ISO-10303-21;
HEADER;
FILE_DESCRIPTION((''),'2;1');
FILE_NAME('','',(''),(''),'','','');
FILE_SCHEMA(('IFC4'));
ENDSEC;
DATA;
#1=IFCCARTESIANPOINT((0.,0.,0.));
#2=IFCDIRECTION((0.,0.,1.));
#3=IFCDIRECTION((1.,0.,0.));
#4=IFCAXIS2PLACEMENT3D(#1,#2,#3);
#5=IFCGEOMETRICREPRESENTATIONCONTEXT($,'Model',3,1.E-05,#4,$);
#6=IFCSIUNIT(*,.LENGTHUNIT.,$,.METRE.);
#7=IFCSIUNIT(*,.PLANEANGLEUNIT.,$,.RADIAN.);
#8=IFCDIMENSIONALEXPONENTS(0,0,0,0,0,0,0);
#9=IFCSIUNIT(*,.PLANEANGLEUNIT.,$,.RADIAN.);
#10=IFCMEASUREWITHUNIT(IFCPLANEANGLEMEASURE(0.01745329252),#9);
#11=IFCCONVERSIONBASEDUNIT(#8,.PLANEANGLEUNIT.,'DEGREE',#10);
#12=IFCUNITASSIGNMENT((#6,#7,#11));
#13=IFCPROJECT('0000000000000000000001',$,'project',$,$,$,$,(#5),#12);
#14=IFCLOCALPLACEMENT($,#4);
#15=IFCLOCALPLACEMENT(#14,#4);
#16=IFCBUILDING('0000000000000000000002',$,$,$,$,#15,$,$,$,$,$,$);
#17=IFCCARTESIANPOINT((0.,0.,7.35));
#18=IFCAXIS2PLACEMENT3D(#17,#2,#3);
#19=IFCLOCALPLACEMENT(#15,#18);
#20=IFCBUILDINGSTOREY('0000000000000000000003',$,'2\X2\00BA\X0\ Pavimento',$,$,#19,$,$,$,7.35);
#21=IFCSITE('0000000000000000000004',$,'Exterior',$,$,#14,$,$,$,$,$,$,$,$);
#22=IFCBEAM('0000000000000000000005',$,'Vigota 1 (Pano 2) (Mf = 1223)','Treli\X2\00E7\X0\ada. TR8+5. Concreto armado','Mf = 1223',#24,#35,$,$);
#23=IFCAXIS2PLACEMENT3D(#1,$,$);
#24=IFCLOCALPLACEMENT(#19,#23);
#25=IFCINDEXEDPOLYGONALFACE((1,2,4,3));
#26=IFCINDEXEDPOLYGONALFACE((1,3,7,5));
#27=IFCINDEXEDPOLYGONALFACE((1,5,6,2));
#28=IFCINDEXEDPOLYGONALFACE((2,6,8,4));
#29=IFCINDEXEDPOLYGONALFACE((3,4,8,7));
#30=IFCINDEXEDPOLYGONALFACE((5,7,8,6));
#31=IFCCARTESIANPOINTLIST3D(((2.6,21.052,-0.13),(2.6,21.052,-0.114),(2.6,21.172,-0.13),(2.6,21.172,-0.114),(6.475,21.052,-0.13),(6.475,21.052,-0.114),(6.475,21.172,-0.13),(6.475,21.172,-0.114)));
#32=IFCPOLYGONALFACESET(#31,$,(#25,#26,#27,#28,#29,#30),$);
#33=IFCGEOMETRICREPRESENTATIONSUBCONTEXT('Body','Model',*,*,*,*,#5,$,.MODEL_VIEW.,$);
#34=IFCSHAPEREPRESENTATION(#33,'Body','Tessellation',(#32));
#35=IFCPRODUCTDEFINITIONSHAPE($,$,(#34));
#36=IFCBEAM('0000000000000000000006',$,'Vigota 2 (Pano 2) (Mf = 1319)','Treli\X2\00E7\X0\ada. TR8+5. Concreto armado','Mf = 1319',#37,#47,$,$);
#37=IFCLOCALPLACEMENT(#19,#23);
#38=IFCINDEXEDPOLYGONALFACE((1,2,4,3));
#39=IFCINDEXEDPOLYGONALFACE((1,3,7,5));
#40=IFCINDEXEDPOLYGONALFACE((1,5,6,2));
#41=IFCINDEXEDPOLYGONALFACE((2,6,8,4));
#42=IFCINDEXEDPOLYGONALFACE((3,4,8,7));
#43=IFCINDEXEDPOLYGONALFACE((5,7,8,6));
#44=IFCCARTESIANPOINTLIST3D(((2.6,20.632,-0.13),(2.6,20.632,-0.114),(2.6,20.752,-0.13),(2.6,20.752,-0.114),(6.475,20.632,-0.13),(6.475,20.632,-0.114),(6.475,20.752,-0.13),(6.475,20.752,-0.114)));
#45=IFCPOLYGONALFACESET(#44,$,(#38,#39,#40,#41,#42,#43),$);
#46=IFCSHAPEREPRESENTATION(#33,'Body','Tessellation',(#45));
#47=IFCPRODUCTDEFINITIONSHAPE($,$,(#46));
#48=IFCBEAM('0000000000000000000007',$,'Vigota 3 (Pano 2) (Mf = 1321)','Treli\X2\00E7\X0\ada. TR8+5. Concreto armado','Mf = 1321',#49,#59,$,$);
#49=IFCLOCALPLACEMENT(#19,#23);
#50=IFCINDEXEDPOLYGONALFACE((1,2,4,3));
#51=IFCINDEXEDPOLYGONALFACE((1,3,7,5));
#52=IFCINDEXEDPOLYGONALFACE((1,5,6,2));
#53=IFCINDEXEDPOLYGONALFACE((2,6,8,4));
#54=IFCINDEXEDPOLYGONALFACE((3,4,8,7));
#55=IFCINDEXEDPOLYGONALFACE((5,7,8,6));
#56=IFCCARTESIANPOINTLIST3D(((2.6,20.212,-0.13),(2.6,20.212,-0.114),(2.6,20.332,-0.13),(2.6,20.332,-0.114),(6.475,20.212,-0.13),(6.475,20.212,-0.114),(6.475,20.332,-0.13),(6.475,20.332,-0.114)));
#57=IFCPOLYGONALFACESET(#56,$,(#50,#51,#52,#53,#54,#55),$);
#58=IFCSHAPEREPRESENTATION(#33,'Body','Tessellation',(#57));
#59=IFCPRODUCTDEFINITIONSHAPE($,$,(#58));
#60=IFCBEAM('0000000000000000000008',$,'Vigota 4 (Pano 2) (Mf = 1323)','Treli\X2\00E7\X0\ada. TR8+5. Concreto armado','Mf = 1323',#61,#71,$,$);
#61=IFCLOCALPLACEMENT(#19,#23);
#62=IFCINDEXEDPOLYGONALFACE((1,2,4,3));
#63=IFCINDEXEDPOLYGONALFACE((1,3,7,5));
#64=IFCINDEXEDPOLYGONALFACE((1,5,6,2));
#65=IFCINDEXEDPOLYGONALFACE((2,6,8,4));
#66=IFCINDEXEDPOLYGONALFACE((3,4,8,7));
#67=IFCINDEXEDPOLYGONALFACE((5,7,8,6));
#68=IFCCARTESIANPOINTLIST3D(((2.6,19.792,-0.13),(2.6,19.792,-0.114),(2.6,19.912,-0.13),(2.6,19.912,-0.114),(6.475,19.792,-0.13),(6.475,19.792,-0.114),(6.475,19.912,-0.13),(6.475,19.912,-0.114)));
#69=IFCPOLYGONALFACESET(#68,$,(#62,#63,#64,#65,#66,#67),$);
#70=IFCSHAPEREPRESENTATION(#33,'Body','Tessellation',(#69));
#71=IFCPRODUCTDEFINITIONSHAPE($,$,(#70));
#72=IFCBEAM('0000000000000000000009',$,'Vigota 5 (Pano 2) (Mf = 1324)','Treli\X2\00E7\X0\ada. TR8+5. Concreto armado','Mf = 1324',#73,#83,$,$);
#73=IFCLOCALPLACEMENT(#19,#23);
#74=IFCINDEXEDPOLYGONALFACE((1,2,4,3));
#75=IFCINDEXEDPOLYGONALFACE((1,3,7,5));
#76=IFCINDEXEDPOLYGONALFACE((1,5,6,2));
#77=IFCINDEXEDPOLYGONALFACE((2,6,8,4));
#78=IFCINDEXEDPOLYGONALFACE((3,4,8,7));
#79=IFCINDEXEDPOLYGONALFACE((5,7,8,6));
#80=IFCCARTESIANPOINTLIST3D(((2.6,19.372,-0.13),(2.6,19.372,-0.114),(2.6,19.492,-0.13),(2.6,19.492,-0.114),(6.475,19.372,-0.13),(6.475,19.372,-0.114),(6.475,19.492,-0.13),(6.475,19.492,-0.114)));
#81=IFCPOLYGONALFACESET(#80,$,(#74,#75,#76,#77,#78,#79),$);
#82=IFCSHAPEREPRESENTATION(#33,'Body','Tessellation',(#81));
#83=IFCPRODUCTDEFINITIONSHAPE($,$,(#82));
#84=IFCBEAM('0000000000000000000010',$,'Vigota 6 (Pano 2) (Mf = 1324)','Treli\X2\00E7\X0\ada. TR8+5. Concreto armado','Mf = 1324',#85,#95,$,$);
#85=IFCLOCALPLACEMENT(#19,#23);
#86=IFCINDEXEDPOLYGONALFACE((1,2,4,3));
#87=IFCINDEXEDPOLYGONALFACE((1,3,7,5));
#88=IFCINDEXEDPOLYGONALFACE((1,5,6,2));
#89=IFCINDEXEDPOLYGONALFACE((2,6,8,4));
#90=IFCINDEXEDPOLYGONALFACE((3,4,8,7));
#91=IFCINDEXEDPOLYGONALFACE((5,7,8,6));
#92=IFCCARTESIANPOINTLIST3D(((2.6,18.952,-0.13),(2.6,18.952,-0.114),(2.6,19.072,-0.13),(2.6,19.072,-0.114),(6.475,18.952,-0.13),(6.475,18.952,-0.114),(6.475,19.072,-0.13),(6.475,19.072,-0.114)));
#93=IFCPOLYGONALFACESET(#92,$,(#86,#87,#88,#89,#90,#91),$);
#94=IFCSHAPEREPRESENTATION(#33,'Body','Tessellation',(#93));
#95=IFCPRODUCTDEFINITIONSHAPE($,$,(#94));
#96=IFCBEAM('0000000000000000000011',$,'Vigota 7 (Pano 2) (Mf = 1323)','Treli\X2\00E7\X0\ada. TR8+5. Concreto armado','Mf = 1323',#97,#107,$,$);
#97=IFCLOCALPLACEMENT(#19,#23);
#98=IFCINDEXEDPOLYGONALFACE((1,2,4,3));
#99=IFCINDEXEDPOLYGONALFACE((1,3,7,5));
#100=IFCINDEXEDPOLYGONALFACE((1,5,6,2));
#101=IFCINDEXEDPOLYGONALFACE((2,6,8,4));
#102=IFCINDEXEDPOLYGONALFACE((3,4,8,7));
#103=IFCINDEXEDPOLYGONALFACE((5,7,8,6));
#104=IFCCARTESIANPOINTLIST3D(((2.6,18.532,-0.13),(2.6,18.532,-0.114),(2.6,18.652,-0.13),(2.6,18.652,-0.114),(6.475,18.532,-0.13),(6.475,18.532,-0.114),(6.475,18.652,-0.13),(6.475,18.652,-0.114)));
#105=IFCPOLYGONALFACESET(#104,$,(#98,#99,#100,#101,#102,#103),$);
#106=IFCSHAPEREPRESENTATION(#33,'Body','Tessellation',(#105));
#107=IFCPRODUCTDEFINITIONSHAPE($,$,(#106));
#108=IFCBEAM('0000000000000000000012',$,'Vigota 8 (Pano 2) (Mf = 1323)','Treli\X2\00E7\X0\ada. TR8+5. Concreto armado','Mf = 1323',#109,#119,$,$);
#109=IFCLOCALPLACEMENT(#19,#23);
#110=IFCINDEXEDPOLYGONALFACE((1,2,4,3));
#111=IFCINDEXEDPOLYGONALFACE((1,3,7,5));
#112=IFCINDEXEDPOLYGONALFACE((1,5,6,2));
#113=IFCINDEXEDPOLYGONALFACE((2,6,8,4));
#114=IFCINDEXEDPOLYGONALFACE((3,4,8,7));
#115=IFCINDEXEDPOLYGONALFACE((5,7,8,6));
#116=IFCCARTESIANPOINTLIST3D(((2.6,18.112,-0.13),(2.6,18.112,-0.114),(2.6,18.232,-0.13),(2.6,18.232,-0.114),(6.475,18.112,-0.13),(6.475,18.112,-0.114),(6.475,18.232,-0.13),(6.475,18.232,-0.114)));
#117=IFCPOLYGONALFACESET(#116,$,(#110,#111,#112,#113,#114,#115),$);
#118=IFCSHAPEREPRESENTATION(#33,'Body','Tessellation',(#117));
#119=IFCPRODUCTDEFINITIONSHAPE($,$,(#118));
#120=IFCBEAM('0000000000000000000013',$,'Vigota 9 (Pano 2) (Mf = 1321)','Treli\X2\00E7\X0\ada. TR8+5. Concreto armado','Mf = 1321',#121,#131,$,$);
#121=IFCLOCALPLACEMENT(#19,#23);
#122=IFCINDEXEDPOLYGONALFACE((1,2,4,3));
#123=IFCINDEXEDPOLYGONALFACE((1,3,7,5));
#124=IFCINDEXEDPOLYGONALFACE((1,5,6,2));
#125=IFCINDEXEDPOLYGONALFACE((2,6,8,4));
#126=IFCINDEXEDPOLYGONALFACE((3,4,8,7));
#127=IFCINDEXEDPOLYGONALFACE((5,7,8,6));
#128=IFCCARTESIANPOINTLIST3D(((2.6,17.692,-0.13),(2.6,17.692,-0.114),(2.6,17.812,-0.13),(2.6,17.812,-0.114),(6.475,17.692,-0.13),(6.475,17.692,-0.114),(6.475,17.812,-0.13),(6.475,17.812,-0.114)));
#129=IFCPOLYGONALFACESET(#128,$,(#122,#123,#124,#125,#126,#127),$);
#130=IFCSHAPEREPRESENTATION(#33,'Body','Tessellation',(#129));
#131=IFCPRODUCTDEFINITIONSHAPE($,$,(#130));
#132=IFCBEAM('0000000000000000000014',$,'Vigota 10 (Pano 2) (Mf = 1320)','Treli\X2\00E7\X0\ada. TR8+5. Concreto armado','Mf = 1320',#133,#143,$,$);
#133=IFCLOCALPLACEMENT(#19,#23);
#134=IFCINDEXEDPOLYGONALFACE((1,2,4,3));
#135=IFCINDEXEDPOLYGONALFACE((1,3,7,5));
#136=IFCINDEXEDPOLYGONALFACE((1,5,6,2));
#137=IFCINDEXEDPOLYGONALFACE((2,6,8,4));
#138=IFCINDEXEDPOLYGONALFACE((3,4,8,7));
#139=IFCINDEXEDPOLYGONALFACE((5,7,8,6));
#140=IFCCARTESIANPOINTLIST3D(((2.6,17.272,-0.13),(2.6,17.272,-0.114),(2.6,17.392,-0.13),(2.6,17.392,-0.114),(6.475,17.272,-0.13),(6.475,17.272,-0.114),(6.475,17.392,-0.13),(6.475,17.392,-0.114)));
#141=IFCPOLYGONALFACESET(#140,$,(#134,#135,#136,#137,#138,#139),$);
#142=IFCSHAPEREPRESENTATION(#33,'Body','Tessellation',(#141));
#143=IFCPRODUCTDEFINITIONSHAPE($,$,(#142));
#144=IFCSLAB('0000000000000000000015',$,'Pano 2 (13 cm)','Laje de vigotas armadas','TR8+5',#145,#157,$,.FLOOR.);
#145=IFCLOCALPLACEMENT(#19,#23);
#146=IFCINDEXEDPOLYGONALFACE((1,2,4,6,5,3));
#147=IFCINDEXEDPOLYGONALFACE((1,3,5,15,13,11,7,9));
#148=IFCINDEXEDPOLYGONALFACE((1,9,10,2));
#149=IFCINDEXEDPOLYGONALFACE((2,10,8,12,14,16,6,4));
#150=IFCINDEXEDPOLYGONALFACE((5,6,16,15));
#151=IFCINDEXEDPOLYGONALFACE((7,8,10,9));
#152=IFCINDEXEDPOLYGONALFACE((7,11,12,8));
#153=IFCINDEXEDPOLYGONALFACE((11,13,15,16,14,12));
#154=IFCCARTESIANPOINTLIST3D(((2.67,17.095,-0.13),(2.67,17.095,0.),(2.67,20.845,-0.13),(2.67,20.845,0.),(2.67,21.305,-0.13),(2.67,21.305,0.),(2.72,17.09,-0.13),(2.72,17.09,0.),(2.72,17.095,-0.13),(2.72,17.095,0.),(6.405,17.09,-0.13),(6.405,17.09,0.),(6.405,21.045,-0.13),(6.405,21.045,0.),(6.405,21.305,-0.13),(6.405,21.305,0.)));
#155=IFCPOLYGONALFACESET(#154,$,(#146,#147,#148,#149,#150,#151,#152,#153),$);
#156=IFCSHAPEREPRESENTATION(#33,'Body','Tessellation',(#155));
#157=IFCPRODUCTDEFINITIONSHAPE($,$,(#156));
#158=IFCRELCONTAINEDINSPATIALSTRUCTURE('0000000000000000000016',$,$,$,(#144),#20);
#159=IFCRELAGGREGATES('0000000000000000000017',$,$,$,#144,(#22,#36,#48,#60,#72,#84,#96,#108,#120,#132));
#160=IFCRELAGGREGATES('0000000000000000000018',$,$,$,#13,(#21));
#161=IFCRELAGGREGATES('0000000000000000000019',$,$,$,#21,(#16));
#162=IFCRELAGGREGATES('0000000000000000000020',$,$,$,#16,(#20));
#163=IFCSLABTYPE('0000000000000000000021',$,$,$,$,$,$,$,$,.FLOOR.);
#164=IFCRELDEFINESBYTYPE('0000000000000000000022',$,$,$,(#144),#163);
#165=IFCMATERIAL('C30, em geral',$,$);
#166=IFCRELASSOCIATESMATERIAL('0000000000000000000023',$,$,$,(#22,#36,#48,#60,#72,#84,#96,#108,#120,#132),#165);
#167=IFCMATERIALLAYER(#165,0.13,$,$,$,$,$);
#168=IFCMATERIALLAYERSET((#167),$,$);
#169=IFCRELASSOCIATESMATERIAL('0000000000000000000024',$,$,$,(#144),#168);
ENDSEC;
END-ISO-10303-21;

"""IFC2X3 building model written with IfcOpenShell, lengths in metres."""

from ifc_helpers import new_model, entity, si_unit, converted_unit, frame, origin_with_axes, place, context, subcontext, project, spatial, polyline, outline, extrude, material, layer, layer_set, layer_usage, type_object, element, aggregate, save


model = new_model("IFC2X3")

# Units and contexts
model_context = context("Model", 3, precision=1e-05, world=origin_with_axes())
body_context = subcontext(model_context, "Body", "Model", "MODEL_VIEW")
ifc_project = project(units=[si_unit("LENGTHUNIT", "METRE"), si_unit("PLANEANGLEUNIT", "RADIAN"), converted_unit("PLANEANGLEUNIT", "DEGREE", entity("IfcPlaneAngleMeasure", 0.01745329252), si_unit("PLANEANGLEUNIT", "RADIAN"), dimensions=[0, 0, 0, 0, 0, 0, 0])], contexts=[model_context])

# Beams
ifc_material = material(Name="C30, em geral")
site_placement = place(None, origin_with_axes())
building_placement = place(site_placement, origin_with_axes())
storey_placement = place(building_placement, frame((0.0, 0.0, 7.35), z_axis=(0.0, 0.0, 1.0), x_axis=(1.0, 0.0, 0.0)))
beam_1_placement = place(storey_placement, frame((2.6, 21.112, -0.122), z_axis=(1.0, 0.0, 0.0), x_axis=(0.0, 1.0, 0.0)))
beam_1 = element("IfcBeam", 1, at=beam_1_placement, material=ifc_material, Name="Vigota 1 (Pano 2) (Mf = 1223)", Description="Treliçada. TR8+5. Concreto armado", ObjectType="Mf = 1223", context=body_context, shape_type="SweptSolid", body=[
    extrude(outline(polyline([(0.06, 0.008), (-0.06, 0.008), (-0.06, -0.008), (0.06, -0.008), (0.06, 0.008)])), origin_with_axes(), (0.0, 0.0, 1.0), 3.875),
])
beam_2_placement = place(storey_placement, frame((2.6, 20.692, -0.122), z_axis=(1.0, 0.0, 0.0), x_axis=(0.0, 1.0, 0.0)))
beam_2 = element("IfcBeam", 2, at=beam_2_placement, material=ifc_material, Name="Vigota 2 (Pano 2) (Mf = 1319)", Description="Treliçada. TR8+5. Concreto armado", ObjectType="Mf = 1319", context=body_context, shape_type="SweptSolid", body=[
    extrude(outline(polyline([(0.06, 0.008), (-0.06, 0.008), (-0.06, -0.008), (0.06, -0.008), (0.06, 0.008)])), origin_with_axes(), (0.0, 0.0, 1.0), 3.875),
])
beam_3_placement = place(storey_placement, frame((2.6, 20.272, -0.122), z_axis=(1.0, 0.0, 0.0), x_axis=(0.0, 1.0, 0.0)))
beam_3 = element("IfcBeam", 3, at=beam_3_placement, material=ifc_material, Name="Vigota 3 (Pano 2) (Mf = 1321)", Description="Treliçada. TR8+5. Concreto armado", ObjectType="Mf = 1321", context=body_context, shape_type="SweptSolid", body=[
    extrude(outline(polyline([(0.06, 0.008), (-0.06, 0.008), (-0.06, -0.008), (0.06, -0.008), (0.06, 0.008)])), origin_with_axes(), (0.0, 0.0, 1.0), 3.875),
])
beam_4_placement = place(storey_placement, frame((2.6, 19.852, -0.122), z_axis=(1.0, 0.0, 0.0), x_axis=(0.0, 1.0, 0.0)))
beam_4 = element("IfcBeam", 4, at=beam_4_placement, material=ifc_material, Name="Vigota 4 (Pano 2) (Mf = 1323)", Description="Treliçada. TR8+5. Concreto armado", ObjectType="Mf = 1323", context=body_context, shape_type="SweptSolid", body=[
    extrude(outline(polyline([(0.06, 0.008), (-0.06, 0.008), (-0.06, -0.008), (0.06, -0.008), (0.06, 0.008)])), origin_with_axes(), (0.0, 0.0, 1.0), 3.875),
])
beam_5_placement = place(storey_placement, frame((2.6, 19.432, -0.122), z_axis=(1.0, 0.0, 0.0), x_axis=(0.0, 1.0, 0.0)))
beam_5 = element("IfcBeam", 5, at=beam_5_placement, material=ifc_material, Name="Vigota 5 (Pano 2) (Mf = 1324)", Description="Treliçada. TR8+5. Concreto armado", ObjectType="Mf = 1324", context=body_context, shape_type="SweptSolid", body=[
    extrude(outline(polyline([(0.06, 0.008), (-0.06, 0.008), (-0.06, -0.008), (0.06, -0.008), (0.06, 0.008)])), origin_with_axes(), (0.0, 0.0, 1.0), 3.875),
])
beam_6_placement = place(storey_placement, frame((2.6, 19.012, -0.122), z_axis=(1.0, 0.0, 0.0), x_axis=(0.0, 1.0, 0.0)))
beam_6 = element("IfcBeam", 6, at=beam_6_placement, material=ifc_material, Name="Vigota 6 (Pano 2) (Mf = 1324)", Description="Treliçada. TR8+5. Concreto armado", ObjectType="Mf = 1324", context=body_context, shape_type="SweptSolid", body=[
    extrude(outline(polyline([(0.06, 0.008), (-0.06, 0.008), (-0.06, -0.008), (0.06, -0.008), (0.06, 0.008)])), origin_with_axes(), (0.0, 0.0, 1.0), 3.875),
])
beam_7_placement = place(storey_placement, frame((2.6, 18.592, -0.122), z_axis=(1.0, 0.0, 0.0), x_axis=(0.0, 1.0, 0.0)))
beam_7 = element("IfcBeam", 7, at=beam_7_placement, material=ifc_material, Name="Vigota 7 (Pano 2) (Mf = 1323)", Description="Treliçada. TR8+5. Concreto armado", ObjectType="Mf = 1323", context=body_context, shape_type="SweptSolid", body=[
    extrude(outline(polyline([(0.06, 0.008), (-0.06, 0.008), (-0.06, -0.008), (0.06, -0.008), (0.06, 0.008)])), origin_with_axes(), (0.0, 0.0, 1.0), 3.875),
])
beam_8_placement = place(storey_placement, frame((2.6, 18.172, -0.122), z_axis=(1.0, 0.0, 0.0), x_axis=(0.0, 1.0, 0.0)))
beam_8 = element("IfcBeam", 8, at=beam_8_placement, material=ifc_material, Name="Vigota 8 (Pano 2) (Mf = 1323)", Description="Treliçada. TR8+5. Concreto armado", ObjectType="Mf = 1323", context=body_context, shape_type="SweptSolid", body=[
    extrude(outline(polyline([(0.06, 0.008), (-0.06, 0.008), (-0.06, -0.008), (0.06, -0.008), (0.06, 0.008)])), origin_with_axes(), (0.0, 0.0, 1.0), 3.875),
])
beam_9_placement = place(storey_placement, frame((2.6, 17.752, -0.122), z_axis=(1.0, 0.0, 0.0), x_axis=(0.0, 1.0, 0.0)))
beam_9 = element("IfcBeam", 9, at=beam_9_placement, material=ifc_material, Name="Vigota 9 (Pano 2) (Mf = 1321)", Description="Treliçada. TR8+5. Concreto armado", ObjectType="Mf = 1321", context=body_context, shape_type="SweptSolid", body=[
    extrude(outline(polyline([(0.06, 0.008), (-0.06, 0.008), (-0.06, -0.008), (0.06, -0.008), (0.06, 0.008)])), origin_with_axes(), (0.0, 0.0, 1.0), 3.875),
])
beam_10_placement = place(storey_placement, frame((2.6, 17.332, -0.122), z_axis=(1.0, 0.0, 0.0), x_axis=(0.0, 1.0, 0.0)))
beam_10 = element("IfcBeam", 10, at=beam_10_placement, material=ifc_material, Name="Vigota 10 (Pano 2) (Mf = 1320)", Description="Treliçada. TR8+5. Concreto armado", ObjectType="Mf = 1320", context=body_context, shape_type="SweptSolid", body=[
    extrude(outline(polyline([(0.06, 0.008), (-0.06, 0.008), (-0.06, -0.008), (0.06, -0.008), (0.06, 0.008)])), origin_with_axes(), (0.0, 0.0, 1.0), 3.875),
])

# Site, building, storey
site = spatial("IfcSite", under=ifc_project, at=site_placement, Name="Exterior")
building = spatial("IfcBuilding", under=site, at=building_placement)
storey = spatial("IfcBuildingStorey", under=building, at=storey_placement, Name="2º Pavimento", Elevation=7.35)

# Slab
ifc_layer_1 = layer(ifc_material, 0.13)
ifc_layer_set_1 = layer_set([ifc_layer_1])
ifc_layer_usage_1 = layer_usage(ifc_layer_set_1, "AXIS3", "POSITIVE", 0.0)
slab_type = type_object("IfcSlabType", PredefinedType="FLOOR")
slab_1_placement = place(storey_placement, frame((0.0, 0.0, -0.13), z_axis=(0.0, 0.0, 1.0), x_axis=(1.0, 0.0, 0.0)))
slab_1 = element("IfcSlab", 11, at=slab_1_placement, inside=storey, type_object=slab_type, material=ifc_layer_usage_1, Name="Pano 2 (13 cm)", Description="Laje de vigotas armadas", ObjectType="TR8+5", PredefinedType="FLOOR", context=body_context, shape_type="SweptSolid", body=[
    extrude(outline(polyline([(2.72, 17.09), (6.405, 17.09), (6.405, 21.045), (6.405, 21.305), (2.67, 21.305), (2.67, 20.845), (2.67, 17.095), (2.72, 17.095), (2.72, 17.09)])), origin_with_axes(), (0.0, 0.0, 1.0), 0.13),
])
aggregate(slab_1, [beam_1, beam_2, beam_3, beam_4, beam_5, beam_6, beam_7, beam_8, beam_9, beam_10])

save(model, "model.ifc")
